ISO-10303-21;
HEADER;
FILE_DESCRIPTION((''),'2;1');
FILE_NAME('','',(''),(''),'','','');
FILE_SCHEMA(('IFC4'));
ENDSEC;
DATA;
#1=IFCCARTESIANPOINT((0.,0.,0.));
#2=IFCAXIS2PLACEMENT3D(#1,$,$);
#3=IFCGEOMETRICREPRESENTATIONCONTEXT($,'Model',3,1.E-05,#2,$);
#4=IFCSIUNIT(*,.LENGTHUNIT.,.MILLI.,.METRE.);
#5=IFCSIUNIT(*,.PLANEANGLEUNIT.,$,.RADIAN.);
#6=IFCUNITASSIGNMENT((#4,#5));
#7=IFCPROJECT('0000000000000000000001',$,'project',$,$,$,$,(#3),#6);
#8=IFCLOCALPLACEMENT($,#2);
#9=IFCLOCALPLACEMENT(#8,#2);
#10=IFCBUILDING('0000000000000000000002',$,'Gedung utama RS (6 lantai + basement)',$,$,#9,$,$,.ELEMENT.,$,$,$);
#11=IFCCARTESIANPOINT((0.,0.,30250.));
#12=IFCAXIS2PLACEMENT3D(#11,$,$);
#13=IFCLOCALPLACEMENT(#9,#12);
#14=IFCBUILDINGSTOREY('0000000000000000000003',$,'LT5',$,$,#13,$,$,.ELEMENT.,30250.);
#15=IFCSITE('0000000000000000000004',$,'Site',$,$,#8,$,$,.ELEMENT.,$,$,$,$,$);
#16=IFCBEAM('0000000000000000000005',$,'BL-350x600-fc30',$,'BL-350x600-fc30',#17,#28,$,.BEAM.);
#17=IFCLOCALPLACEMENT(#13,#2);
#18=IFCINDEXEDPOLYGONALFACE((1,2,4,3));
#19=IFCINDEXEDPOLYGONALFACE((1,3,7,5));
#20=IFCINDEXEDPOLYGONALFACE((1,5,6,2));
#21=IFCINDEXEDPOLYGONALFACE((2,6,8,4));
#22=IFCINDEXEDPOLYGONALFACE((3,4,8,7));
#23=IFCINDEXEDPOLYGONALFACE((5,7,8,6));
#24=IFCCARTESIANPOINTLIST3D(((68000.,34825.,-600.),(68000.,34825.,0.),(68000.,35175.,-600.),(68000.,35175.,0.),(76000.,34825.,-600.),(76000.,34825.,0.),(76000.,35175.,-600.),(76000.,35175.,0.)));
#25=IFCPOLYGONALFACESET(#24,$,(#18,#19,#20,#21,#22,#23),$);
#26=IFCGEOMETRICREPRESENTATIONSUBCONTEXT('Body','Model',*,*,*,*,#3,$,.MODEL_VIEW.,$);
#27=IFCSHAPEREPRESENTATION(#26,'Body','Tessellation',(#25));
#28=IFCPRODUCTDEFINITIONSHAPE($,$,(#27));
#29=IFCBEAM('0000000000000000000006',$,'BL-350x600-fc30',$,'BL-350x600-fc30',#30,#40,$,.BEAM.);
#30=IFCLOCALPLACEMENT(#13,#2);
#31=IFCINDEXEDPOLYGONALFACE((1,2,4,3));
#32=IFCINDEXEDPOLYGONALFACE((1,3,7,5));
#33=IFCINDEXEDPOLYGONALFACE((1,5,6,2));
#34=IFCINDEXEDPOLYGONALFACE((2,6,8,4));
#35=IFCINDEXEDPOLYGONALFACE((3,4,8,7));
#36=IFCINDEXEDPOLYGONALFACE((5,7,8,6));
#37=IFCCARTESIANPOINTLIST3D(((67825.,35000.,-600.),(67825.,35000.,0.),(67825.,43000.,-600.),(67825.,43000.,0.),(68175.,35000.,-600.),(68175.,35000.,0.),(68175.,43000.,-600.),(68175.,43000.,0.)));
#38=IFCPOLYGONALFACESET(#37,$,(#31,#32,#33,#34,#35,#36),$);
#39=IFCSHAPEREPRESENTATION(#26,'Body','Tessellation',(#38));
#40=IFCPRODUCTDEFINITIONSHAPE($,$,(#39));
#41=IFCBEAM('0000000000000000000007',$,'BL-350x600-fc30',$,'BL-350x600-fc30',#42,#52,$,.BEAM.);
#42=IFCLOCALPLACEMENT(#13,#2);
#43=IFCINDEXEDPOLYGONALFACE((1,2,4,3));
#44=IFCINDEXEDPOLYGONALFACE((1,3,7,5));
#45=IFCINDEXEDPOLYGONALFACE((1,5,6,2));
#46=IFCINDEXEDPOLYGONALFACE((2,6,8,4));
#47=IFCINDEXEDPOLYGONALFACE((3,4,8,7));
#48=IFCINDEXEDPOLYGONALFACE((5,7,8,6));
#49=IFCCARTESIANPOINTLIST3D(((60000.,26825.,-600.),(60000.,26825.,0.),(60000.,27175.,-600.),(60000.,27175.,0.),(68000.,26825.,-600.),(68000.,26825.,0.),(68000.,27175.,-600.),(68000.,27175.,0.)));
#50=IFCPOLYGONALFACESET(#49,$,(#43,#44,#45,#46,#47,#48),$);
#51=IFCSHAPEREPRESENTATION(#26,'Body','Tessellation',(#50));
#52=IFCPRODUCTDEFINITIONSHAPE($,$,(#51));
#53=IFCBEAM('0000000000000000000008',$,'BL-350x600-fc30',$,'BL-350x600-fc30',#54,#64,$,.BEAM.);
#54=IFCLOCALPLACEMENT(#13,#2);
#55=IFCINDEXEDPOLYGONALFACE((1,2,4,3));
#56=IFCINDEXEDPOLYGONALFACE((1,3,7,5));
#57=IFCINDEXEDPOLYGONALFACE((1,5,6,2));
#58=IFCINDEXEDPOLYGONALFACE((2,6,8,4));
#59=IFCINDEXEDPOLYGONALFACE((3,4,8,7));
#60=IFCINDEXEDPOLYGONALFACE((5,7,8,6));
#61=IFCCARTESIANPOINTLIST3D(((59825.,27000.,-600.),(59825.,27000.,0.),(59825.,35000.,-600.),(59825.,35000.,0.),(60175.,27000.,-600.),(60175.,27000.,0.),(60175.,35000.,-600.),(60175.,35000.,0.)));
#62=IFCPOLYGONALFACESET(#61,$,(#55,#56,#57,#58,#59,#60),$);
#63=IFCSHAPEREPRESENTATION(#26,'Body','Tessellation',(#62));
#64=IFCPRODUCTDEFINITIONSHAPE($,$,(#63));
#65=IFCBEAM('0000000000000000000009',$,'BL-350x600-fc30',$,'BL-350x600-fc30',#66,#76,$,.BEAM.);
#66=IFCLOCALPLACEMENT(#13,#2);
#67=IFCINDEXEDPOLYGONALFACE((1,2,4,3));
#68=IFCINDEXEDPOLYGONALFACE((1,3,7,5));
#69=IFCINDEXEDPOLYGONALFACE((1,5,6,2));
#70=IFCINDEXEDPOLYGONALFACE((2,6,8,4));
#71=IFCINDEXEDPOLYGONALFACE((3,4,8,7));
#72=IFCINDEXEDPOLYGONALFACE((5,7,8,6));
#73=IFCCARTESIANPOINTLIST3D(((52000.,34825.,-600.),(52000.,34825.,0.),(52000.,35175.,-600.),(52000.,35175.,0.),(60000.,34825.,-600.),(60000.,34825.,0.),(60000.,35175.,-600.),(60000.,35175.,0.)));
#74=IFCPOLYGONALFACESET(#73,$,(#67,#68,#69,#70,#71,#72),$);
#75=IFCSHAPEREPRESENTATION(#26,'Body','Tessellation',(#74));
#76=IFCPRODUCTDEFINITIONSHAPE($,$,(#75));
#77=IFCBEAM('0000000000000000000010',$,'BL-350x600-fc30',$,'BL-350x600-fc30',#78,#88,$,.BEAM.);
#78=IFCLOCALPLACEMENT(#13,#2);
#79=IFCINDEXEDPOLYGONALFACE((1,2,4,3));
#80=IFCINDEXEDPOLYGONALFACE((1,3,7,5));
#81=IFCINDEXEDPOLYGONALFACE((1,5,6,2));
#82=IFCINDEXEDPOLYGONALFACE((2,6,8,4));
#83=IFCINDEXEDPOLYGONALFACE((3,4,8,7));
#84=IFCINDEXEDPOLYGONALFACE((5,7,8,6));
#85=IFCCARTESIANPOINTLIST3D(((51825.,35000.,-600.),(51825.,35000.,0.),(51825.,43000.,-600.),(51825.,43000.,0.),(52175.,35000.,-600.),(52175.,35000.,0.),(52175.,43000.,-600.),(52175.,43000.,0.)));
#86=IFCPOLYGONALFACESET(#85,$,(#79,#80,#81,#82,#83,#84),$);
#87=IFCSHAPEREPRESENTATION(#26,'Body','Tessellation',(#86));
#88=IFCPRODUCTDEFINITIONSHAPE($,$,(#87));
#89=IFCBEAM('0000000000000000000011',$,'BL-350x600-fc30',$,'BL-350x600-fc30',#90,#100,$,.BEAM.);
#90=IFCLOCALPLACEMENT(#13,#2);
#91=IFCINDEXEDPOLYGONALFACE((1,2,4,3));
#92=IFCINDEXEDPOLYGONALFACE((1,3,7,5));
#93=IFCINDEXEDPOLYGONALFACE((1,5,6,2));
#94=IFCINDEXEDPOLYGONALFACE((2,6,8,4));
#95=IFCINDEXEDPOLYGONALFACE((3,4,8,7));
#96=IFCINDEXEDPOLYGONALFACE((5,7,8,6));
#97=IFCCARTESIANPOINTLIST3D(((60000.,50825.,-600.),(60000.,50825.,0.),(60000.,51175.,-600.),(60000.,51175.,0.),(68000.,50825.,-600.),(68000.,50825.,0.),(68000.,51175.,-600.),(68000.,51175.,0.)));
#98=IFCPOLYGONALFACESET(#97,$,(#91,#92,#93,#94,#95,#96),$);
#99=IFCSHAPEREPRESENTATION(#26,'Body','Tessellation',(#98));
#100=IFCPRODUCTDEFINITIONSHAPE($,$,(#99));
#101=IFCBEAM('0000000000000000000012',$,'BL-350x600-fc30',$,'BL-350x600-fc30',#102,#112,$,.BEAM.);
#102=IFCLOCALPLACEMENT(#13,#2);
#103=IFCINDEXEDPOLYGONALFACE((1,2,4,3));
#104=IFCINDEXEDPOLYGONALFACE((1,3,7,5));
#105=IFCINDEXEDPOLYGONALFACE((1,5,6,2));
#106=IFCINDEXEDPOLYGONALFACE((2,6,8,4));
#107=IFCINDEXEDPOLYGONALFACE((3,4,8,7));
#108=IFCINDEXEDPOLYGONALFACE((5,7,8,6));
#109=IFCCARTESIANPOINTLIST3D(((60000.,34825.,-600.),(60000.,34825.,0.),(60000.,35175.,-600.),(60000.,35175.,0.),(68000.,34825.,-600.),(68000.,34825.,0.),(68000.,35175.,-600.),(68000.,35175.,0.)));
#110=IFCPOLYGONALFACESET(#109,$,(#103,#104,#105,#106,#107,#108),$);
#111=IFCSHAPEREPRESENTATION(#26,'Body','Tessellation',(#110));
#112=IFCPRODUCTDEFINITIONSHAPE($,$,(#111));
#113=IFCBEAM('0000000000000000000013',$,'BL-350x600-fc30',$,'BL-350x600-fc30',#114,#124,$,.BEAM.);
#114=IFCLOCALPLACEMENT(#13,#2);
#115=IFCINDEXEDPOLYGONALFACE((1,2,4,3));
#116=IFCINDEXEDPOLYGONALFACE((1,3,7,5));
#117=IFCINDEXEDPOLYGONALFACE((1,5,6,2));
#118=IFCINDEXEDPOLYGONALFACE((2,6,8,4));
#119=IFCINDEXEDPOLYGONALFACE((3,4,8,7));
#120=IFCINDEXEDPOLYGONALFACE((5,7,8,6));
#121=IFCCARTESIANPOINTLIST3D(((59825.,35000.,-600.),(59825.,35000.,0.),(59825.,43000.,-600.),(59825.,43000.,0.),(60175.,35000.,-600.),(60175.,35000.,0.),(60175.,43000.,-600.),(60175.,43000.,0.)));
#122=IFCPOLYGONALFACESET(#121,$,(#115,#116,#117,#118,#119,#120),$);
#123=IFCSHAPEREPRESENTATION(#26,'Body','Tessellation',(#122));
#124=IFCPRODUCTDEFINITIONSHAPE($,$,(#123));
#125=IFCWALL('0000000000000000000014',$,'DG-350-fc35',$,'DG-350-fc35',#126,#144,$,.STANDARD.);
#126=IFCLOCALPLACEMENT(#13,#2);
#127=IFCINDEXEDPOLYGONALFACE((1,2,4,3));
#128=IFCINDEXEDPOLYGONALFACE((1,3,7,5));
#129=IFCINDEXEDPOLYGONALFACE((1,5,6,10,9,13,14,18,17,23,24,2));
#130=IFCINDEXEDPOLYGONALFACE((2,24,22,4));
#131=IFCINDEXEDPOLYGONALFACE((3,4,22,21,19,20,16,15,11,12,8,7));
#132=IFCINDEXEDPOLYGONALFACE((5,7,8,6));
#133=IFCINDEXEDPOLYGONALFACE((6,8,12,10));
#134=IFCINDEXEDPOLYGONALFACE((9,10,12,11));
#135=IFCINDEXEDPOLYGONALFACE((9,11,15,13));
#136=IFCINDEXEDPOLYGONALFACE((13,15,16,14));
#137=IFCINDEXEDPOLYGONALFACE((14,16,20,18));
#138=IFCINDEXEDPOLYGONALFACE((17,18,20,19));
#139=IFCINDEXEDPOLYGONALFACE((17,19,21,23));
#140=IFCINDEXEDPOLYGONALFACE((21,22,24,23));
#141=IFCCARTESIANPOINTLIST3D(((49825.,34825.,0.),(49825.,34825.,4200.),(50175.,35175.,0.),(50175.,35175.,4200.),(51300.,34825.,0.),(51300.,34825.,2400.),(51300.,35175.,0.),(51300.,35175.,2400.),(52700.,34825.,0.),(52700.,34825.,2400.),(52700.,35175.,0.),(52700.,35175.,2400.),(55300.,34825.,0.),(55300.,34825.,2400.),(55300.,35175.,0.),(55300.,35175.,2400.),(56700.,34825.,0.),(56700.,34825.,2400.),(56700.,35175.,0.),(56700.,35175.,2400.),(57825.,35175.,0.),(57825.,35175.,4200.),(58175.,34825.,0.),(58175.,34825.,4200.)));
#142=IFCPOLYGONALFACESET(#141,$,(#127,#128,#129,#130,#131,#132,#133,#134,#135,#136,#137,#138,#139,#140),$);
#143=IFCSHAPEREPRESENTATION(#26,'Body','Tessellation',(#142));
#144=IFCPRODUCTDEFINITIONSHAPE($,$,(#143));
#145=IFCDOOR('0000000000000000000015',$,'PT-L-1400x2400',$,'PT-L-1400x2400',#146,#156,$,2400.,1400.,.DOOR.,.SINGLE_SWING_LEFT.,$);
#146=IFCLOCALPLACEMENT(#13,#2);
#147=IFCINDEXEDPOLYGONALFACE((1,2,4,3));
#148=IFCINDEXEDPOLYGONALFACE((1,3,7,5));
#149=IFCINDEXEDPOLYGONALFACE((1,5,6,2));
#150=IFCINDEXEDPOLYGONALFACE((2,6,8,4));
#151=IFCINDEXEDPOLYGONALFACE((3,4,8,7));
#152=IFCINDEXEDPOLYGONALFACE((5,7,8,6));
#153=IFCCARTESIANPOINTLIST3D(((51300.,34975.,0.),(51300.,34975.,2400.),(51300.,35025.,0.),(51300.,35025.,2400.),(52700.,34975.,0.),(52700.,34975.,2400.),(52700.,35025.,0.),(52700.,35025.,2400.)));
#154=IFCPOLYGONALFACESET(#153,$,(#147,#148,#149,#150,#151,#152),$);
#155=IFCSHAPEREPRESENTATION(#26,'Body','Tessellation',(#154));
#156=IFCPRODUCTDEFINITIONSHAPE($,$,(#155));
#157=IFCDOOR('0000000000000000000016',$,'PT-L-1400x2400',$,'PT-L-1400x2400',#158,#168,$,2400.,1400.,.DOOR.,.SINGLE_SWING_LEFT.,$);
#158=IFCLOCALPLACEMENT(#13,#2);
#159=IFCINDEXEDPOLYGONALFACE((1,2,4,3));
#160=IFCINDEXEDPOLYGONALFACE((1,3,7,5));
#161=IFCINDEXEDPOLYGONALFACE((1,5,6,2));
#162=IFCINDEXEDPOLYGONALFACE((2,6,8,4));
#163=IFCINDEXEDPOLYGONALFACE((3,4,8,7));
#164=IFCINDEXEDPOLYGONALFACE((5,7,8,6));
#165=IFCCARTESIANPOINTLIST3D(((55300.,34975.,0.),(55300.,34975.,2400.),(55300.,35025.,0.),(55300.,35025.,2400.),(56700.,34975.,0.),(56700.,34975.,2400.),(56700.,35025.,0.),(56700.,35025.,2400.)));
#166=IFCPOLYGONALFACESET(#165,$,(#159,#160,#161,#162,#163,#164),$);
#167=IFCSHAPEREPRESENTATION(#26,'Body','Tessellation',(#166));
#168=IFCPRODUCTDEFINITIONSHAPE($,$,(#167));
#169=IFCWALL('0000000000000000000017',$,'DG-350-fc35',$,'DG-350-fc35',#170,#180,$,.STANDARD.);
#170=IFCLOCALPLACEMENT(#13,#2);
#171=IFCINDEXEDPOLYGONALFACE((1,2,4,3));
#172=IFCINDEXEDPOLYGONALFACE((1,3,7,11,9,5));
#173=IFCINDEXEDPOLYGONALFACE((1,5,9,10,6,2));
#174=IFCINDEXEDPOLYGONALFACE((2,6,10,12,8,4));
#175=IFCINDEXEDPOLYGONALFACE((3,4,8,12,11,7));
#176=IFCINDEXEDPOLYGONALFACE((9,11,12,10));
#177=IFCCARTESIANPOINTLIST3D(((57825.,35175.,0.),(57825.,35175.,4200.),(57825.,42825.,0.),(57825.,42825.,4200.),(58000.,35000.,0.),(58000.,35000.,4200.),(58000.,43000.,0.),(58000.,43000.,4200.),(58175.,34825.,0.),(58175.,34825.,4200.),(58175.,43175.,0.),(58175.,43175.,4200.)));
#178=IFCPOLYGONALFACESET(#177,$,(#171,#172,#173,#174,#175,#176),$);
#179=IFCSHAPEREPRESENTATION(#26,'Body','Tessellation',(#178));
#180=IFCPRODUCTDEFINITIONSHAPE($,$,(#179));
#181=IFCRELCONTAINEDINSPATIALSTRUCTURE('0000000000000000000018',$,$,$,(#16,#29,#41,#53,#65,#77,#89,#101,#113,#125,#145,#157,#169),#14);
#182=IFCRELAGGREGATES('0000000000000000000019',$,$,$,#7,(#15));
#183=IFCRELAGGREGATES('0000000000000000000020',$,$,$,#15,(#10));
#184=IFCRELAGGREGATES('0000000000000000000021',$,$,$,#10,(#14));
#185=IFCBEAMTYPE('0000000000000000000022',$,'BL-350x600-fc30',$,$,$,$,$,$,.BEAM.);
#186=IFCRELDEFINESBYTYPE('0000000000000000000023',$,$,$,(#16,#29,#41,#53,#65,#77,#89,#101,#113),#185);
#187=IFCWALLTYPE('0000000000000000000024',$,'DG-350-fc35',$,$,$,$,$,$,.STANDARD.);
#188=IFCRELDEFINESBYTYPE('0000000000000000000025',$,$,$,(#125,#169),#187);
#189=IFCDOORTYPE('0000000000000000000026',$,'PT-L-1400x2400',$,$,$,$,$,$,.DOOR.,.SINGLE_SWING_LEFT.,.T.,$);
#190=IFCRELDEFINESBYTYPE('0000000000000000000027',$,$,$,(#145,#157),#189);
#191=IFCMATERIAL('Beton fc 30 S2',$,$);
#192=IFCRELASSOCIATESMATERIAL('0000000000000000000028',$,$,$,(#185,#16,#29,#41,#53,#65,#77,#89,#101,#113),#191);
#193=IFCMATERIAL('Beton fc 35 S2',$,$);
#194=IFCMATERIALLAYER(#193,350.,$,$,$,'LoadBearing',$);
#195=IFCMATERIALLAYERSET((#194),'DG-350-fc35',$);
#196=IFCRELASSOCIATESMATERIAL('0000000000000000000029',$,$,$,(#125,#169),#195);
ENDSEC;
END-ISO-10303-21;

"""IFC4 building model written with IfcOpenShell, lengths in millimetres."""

from ifc_helpers import new_model, si_unit, frame, frame_2d, origin, origin_2d, place, context, subcontext, project, spatial, polyline, rectangle, outline, extrude, material, layer, layer_set, layer_usage, material_profile, profile_set, profile_usage, type_object, element, fill, save


model = new_model("IFC4")

# Units and contexts
model_context = context("Model", 3, precision=1e-05, world=origin())
body_context = subcontext(model_context, "Body", "Model", "MODEL_VIEW")
ifc_project = project(units=[si_unit("LENGTHUNIT", "METRE", prefix="MILLI"), si_unit("PLANEANGLEUNIT", "RADIAN")], contexts=[model_context])

# Site, building, storey
site_placement = place(None, origin())
site = spatial("IfcSite", under=ifc_project, at=site_placement, Name="Site", CompositionType="ELEMENT")
building_placement = place(site_placement, origin())
building = spatial("IfcBuilding", under=site, at=building_placement, Name="Gedung utama RS (6 lantai + basement)", CompositionType="ELEMENT")
storey_placement = place(building_placement, frame((0.0, 0.0, 30250.0)))
storey = spatial("IfcBuildingStorey", under=building, at=storey_placement, Name="LT5", CompositionType="ELEMENT", Elevation=30250.0)

# Beams
ifc_material_1 = material(Name="Beton fc 30 S2")
ifc_material_profile_1 = material_profile(ifc_material_1, rectangle(XDim=350.0, YDim=600.0, at=origin_2d()), Name="BL-350x600-fc30")
ifc_profile_set_1 = profile_set([ifc_material_profile_1], Name="BL-350x600-fc30")
ifc_profile_usage_1 = profile_usage(ifc_profile_set_1, cardinal=8)
beam_type = type_object("IfcBeamType", Name="BL-350x600-fc30", PredefinedType="BEAM", material=ifc_profile_set_1)
for number, where, name in (
    (1, (68000.0, 35000.0, -300.0), "BL-350x600-fc30"),
):
    element("IfcBeam", number, at=place(storey_placement, frame(where)), inside=storey, type_object=beam_type, material=ifc_profile_usage_1, Name=name, ObjectType="BL-350x600-fc30", PredefinedType="BEAM", context=body_context, shape_type="SweptSolid", body=[
        extrude(rectangle(XDim=350.0, YDim=600.0, at=origin_2d()), frame((0.0, 0.0, 0.0), z_axis=(1.0, 0.0, 0.0), x_axis=(0.0, 1.0, 0.0)), (0.0, 0.0, 1.0), 8000.0),
    ])
beam_1_placement = place(storey_placement, frame((68000.0, 35000.0, -300.0)))
element("IfcBeam", 2, at=beam_1_placement, inside=storey, type_object=beam_type, material=ifc_profile_usage_1, Name="BL-350x600-fc30", ObjectType="BL-350x600-fc30", PredefinedType="BEAM", context=body_context, shape_type="SweptSolid", body=[
    extrude(rectangle(XDim=350.0, YDim=600.0, at=origin_2d()), frame((0.0, 0.0, 0.0), z_axis=(0.0, 1.0, 0.0), x_axis=(-1.0, 0.0, 0.0)), (0.0, 0.0, 1.0), 8000.0),
])
beam_2_placement = place(storey_placement, frame((60000.0, 27000.0, -300.0)))
element("IfcBeam", 3, at=beam_2_placement, inside=storey, type_object=beam_type, material=ifc_profile_usage_1, Name="BL-350x600-fc30", ObjectType="BL-350x600-fc30", PredefinedType="BEAM", context=body_context, shape_type="SweptSolid", body=[
    extrude(rectangle(XDim=350.0, YDim=600.0, at=origin_2d()), frame((0.0, 0.0, 0.0), z_axis=(1.0, 0.0, 0.0), x_axis=(0.0, 1.0, 0.0)), (0.0, 0.0, 1.0), 8000.0),
])
beam_3_placement = place(storey_placement, frame((60000.0, 27000.0, -300.0)))
element("IfcBeam", 4, at=beam_3_placement, inside=storey, type_object=beam_type, material=ifc_profile_usage_1, Name="BL-350x600-fc30", ObjectType="BL-350x600-fc30", PredefinedType="BEAM", context=body_context, shape_type="SweptSolid", body=[
    extrude(rectangle(XDim=350.0, YDim=600.0, at=origin_2d()), frame((0.0, 0.0, 0.0), z_axis=(0.0, 1.0, 0.0), x_axis=(-1.0, 0.0, 0.0)), (0.0, 0.0, 1.0), 8000.0),
])
beam_4_placement = place(storey_placement, frame((52000.0, 35000.0, -300.0)))
element("IfcBeam", 5, at=beam_4_placement, inside=storey, type_object=beam_type, material=ifc_profile_usage_1, Name="BL-350x600-fc30", ObjectType="BL-350x600-fc30", PredefinedType="BEAM", context=body_context, shape_type="SweptSolid", body=[
    extrude(rectangle(XDim=350.0, YDim=600.0, at=origin_2d()), frame((0.0, 0.0, 0.0), z_axis=(1.0, 0.0, 0.0), x_axis=(0.0, 1.0, 0.0)), (0.0, 0.0, 1.0), 8000.0),
])
beam_5_placement = place(storey_placement, frame((52000.0, 35000.0, -300.0)))
element("IfcBeam", 6, at=beam_5_placement, inside=storey, type_object=beam_type, material=ifc_profile_usage_1, Name="BL-350x600-fc30", ObjectType="BL-350x600-fc30", PredefinedType="BEAM", context=body_context, shape_type="SweptSolid", body=[
    extrude(rectangle(XDim=350.0, YDim=600.0, at=origin_2d()), frame((0.0, 0.0, 0.0), z_axis=(0.0, 1.0, 0.0), x_axis=(-1.0, 0.0, 0.0)), (0.0, 0.0, 1.0), 8000.0),
])
for number, where, name in (
    (7, (60000.0, 51000.0, -300.0), "BL-350x600-fc30"),
    (8, (60000.0, 35000.0, -300.0), "BL-350x600-fc30"),
):
    element("IfcBeam", number, at=place(storey_placement, frame(where)), inside=storey, type_object=beam_type, material=ifc_profile_usage_1, Name=name, ObjectType="BL-350x600-fc30", PredefinedType="BEAM", context=body_context, shape_type="SweptSolid", body=[
        extrude(rectangle(XDim=350.0, YDim=600.0, at=origin_2d()), frame((0.0, 0.0, 0.0), z_axis=(1.0, 0.0, 0.0), x_axis=(0.0, 1.0, 0.0)), (0.0, 0.0, 1.0), 8000.0),
    ])
beam_6_placement = place(storey_placement, frame((60000.0, 35000.0, -300.0)))
element("IfcBeam", 9, at=beam_6_placement, inside=storey, type_object=beam_type, material=ifc_profile_usage_1, Name="BL-350x600-fc30", ObjectType="BL-350x600-fc30", PredefinedType="BEAM", context=body_context, shape_type="SweptSolid", body=[
    extrude(rectangle(XDim=350.0, YDim=600.0, at=origin_2d()), frame((0.0, 0.0, 0.0), z_axis=(0.0, 1.0, 0.0), x_axis=(-1.0, 0.0, 0.0)), (0.0, 0.0, 1.0), 8000.0),
])

# Wall, openings, doors
ifc_material_2 = material(Name="Beton fc 35 S2")
ifc_layer = layer(ifc_material_2, 350.0, Category="LoadBearing")
ifc_layer_set = layer_set([ifc_layer], Name="DG-350-fc35")
ifc_layer_usage = layer_usage(ifc_layer_set, "AXIS2", "NEGATIVE", 175.0)
wall_type = type_object("IfcWallType", Name="DG-350-fc35", PredefinedType="STANDARD")
wall_placement = place(storey_placement, frame((50000.0, 35000.0, 0.0), z_axis=(0.0, 0.0, 1.0), x_axis=(1.0, 0.0, 0.0)))
wall = element("IfcWall", 10, at=wall_placement, inside=storey, type_object=wall_type, material=ifc_layer_usage, Name="DG-350-fc35", ObjectType="DG-350-fc35", PredefinedType="STANDARD", context=body_context, shape_type="SweptSolid", body=[
    extrude(outline(polyline([(-175.0, -175.0), (0.0, 0.0), (175.0, 175.0), (7825.0, 175.0), (8000.0, 0.0), (8175.0, -175.0), (-175.0, -175.0)])), origin(), (0.0, 0.0, 1.0), 4200.0),
])
opening_1_placement = place(wall_placement, frame((1300.0, 0.0, 0.0), z_axis=(0.0, 0.0, 1.0), x_axis=(1.0, 0.0, 0.0)))
opening_1 = element("IfcOpeningElement", 11, at=opening_1_placement, cuts=wall, PredefinedType="OPENING", context=body_context, shape_type="SweptSolid", body=[
    extrude(rectangle(XDim=1400.0, YDim=370.0, at=frame_2d((700.0, 0.0))), origin(), (0.0, 0.0, 1.0), 2400.0),
])
opening_2_placement = place(wall_placement, frame((5300.0, 0.0, 0.0), z_axis=(0.0, 0.0, 1.0), x_axis=(1.0, 0.0, 0.0)))
opening_2 = element("IfcOpeningElement", 12, at=opening_2_placement, cuts=wall, PredefinedType="OPENING", context=body_context, shape_type="SweptSolid", body=[
    extrude(rectangle(XDim=1400.0, YDim=370.0, at=frame_2d((700.0, 0.0))), origin(), (0.0, 0.0, 1.0), 2400.0),
])
door_type = type_object("IfcDoorType", Name="PT-L-1400x2400", OperationType="SINGLE_SWING_LEFT", ParameterTakesPrecedence=True, PredefinedType="DOOR")
door_1_placement = place(opening_1_placement, origin())
door_1 = element("IfcDoor", 13, at=door_1_placement, inside=storey, type_object=door_type, Name="PT-L-1400x2400", ObjectType="PT-L-1400x2400", OperationType="SINGLE_SWING_LEFT", OverallHeight=2400.0, OverallWidth=1400.0, PredefinedType="DOOR", context=body_context, shape_type="SweptSolid", body=[
    extrude(rectangle(XDim=1400.0, YDim=50.0, at=frame_2d((700.0, 0.0))), origin(), (0.0, 0.0, 1.0), 2400.0),
])
fill(opening_1, door_1)
door_2_placement = place(opening_2_placement, origin())
door_2 = element("IfcDoor", 14, at=door_2_placement, inside=storey, type_object=door_type, Name="PT-L-1400x2400", ObjectType="PT-L-1400x2400", OperationType="SINGLE_SWING_LEFT", OverallHeight=2400.0, OverallWidth=1400.0, PredefinedType="DOOR", context=body_context, shape_type="SweptSolid", body=[
    extrude(rectangle(XDim=1400.0, YDim=50.0, at=frame_2d((700.0, 0.0))), origin(), (0.0, 0.0, 1.0), 2400.0),
])
fill(opening_2, door_2)

# Wall
for number, where, z_axis, x_axis, name in (
    (15, (58000.0, 35000.0, 0.0), (0.0, 0.0, 1.0), (0.0, 1.0, 0.0), "DG-350-fc35"),
):
    element("IfcWall", number, at=place(storey_placement, frame(where, z_axis=z_axis, x_axis=x_axis)), inside=storey, type_object=wall_type, material=ifc_layer_usage, Name=name, ObjectType="DG-350-fc35", PredefinedType="STANDARD", context=body_context, shape_type="SweptSolid", body=[
        extrude(outline(polyline([(-175.0, -175.0), (0.0, 0.0), (175.0, 175.0), (7825.0, 175.0), (8000.0, 0.0), (8175.0, -175.0), (-175.0, -175.0)])), origin(), (0.0, 0.0, 1.0), 4200.0),
    ])

save(model, "model.ifc")
